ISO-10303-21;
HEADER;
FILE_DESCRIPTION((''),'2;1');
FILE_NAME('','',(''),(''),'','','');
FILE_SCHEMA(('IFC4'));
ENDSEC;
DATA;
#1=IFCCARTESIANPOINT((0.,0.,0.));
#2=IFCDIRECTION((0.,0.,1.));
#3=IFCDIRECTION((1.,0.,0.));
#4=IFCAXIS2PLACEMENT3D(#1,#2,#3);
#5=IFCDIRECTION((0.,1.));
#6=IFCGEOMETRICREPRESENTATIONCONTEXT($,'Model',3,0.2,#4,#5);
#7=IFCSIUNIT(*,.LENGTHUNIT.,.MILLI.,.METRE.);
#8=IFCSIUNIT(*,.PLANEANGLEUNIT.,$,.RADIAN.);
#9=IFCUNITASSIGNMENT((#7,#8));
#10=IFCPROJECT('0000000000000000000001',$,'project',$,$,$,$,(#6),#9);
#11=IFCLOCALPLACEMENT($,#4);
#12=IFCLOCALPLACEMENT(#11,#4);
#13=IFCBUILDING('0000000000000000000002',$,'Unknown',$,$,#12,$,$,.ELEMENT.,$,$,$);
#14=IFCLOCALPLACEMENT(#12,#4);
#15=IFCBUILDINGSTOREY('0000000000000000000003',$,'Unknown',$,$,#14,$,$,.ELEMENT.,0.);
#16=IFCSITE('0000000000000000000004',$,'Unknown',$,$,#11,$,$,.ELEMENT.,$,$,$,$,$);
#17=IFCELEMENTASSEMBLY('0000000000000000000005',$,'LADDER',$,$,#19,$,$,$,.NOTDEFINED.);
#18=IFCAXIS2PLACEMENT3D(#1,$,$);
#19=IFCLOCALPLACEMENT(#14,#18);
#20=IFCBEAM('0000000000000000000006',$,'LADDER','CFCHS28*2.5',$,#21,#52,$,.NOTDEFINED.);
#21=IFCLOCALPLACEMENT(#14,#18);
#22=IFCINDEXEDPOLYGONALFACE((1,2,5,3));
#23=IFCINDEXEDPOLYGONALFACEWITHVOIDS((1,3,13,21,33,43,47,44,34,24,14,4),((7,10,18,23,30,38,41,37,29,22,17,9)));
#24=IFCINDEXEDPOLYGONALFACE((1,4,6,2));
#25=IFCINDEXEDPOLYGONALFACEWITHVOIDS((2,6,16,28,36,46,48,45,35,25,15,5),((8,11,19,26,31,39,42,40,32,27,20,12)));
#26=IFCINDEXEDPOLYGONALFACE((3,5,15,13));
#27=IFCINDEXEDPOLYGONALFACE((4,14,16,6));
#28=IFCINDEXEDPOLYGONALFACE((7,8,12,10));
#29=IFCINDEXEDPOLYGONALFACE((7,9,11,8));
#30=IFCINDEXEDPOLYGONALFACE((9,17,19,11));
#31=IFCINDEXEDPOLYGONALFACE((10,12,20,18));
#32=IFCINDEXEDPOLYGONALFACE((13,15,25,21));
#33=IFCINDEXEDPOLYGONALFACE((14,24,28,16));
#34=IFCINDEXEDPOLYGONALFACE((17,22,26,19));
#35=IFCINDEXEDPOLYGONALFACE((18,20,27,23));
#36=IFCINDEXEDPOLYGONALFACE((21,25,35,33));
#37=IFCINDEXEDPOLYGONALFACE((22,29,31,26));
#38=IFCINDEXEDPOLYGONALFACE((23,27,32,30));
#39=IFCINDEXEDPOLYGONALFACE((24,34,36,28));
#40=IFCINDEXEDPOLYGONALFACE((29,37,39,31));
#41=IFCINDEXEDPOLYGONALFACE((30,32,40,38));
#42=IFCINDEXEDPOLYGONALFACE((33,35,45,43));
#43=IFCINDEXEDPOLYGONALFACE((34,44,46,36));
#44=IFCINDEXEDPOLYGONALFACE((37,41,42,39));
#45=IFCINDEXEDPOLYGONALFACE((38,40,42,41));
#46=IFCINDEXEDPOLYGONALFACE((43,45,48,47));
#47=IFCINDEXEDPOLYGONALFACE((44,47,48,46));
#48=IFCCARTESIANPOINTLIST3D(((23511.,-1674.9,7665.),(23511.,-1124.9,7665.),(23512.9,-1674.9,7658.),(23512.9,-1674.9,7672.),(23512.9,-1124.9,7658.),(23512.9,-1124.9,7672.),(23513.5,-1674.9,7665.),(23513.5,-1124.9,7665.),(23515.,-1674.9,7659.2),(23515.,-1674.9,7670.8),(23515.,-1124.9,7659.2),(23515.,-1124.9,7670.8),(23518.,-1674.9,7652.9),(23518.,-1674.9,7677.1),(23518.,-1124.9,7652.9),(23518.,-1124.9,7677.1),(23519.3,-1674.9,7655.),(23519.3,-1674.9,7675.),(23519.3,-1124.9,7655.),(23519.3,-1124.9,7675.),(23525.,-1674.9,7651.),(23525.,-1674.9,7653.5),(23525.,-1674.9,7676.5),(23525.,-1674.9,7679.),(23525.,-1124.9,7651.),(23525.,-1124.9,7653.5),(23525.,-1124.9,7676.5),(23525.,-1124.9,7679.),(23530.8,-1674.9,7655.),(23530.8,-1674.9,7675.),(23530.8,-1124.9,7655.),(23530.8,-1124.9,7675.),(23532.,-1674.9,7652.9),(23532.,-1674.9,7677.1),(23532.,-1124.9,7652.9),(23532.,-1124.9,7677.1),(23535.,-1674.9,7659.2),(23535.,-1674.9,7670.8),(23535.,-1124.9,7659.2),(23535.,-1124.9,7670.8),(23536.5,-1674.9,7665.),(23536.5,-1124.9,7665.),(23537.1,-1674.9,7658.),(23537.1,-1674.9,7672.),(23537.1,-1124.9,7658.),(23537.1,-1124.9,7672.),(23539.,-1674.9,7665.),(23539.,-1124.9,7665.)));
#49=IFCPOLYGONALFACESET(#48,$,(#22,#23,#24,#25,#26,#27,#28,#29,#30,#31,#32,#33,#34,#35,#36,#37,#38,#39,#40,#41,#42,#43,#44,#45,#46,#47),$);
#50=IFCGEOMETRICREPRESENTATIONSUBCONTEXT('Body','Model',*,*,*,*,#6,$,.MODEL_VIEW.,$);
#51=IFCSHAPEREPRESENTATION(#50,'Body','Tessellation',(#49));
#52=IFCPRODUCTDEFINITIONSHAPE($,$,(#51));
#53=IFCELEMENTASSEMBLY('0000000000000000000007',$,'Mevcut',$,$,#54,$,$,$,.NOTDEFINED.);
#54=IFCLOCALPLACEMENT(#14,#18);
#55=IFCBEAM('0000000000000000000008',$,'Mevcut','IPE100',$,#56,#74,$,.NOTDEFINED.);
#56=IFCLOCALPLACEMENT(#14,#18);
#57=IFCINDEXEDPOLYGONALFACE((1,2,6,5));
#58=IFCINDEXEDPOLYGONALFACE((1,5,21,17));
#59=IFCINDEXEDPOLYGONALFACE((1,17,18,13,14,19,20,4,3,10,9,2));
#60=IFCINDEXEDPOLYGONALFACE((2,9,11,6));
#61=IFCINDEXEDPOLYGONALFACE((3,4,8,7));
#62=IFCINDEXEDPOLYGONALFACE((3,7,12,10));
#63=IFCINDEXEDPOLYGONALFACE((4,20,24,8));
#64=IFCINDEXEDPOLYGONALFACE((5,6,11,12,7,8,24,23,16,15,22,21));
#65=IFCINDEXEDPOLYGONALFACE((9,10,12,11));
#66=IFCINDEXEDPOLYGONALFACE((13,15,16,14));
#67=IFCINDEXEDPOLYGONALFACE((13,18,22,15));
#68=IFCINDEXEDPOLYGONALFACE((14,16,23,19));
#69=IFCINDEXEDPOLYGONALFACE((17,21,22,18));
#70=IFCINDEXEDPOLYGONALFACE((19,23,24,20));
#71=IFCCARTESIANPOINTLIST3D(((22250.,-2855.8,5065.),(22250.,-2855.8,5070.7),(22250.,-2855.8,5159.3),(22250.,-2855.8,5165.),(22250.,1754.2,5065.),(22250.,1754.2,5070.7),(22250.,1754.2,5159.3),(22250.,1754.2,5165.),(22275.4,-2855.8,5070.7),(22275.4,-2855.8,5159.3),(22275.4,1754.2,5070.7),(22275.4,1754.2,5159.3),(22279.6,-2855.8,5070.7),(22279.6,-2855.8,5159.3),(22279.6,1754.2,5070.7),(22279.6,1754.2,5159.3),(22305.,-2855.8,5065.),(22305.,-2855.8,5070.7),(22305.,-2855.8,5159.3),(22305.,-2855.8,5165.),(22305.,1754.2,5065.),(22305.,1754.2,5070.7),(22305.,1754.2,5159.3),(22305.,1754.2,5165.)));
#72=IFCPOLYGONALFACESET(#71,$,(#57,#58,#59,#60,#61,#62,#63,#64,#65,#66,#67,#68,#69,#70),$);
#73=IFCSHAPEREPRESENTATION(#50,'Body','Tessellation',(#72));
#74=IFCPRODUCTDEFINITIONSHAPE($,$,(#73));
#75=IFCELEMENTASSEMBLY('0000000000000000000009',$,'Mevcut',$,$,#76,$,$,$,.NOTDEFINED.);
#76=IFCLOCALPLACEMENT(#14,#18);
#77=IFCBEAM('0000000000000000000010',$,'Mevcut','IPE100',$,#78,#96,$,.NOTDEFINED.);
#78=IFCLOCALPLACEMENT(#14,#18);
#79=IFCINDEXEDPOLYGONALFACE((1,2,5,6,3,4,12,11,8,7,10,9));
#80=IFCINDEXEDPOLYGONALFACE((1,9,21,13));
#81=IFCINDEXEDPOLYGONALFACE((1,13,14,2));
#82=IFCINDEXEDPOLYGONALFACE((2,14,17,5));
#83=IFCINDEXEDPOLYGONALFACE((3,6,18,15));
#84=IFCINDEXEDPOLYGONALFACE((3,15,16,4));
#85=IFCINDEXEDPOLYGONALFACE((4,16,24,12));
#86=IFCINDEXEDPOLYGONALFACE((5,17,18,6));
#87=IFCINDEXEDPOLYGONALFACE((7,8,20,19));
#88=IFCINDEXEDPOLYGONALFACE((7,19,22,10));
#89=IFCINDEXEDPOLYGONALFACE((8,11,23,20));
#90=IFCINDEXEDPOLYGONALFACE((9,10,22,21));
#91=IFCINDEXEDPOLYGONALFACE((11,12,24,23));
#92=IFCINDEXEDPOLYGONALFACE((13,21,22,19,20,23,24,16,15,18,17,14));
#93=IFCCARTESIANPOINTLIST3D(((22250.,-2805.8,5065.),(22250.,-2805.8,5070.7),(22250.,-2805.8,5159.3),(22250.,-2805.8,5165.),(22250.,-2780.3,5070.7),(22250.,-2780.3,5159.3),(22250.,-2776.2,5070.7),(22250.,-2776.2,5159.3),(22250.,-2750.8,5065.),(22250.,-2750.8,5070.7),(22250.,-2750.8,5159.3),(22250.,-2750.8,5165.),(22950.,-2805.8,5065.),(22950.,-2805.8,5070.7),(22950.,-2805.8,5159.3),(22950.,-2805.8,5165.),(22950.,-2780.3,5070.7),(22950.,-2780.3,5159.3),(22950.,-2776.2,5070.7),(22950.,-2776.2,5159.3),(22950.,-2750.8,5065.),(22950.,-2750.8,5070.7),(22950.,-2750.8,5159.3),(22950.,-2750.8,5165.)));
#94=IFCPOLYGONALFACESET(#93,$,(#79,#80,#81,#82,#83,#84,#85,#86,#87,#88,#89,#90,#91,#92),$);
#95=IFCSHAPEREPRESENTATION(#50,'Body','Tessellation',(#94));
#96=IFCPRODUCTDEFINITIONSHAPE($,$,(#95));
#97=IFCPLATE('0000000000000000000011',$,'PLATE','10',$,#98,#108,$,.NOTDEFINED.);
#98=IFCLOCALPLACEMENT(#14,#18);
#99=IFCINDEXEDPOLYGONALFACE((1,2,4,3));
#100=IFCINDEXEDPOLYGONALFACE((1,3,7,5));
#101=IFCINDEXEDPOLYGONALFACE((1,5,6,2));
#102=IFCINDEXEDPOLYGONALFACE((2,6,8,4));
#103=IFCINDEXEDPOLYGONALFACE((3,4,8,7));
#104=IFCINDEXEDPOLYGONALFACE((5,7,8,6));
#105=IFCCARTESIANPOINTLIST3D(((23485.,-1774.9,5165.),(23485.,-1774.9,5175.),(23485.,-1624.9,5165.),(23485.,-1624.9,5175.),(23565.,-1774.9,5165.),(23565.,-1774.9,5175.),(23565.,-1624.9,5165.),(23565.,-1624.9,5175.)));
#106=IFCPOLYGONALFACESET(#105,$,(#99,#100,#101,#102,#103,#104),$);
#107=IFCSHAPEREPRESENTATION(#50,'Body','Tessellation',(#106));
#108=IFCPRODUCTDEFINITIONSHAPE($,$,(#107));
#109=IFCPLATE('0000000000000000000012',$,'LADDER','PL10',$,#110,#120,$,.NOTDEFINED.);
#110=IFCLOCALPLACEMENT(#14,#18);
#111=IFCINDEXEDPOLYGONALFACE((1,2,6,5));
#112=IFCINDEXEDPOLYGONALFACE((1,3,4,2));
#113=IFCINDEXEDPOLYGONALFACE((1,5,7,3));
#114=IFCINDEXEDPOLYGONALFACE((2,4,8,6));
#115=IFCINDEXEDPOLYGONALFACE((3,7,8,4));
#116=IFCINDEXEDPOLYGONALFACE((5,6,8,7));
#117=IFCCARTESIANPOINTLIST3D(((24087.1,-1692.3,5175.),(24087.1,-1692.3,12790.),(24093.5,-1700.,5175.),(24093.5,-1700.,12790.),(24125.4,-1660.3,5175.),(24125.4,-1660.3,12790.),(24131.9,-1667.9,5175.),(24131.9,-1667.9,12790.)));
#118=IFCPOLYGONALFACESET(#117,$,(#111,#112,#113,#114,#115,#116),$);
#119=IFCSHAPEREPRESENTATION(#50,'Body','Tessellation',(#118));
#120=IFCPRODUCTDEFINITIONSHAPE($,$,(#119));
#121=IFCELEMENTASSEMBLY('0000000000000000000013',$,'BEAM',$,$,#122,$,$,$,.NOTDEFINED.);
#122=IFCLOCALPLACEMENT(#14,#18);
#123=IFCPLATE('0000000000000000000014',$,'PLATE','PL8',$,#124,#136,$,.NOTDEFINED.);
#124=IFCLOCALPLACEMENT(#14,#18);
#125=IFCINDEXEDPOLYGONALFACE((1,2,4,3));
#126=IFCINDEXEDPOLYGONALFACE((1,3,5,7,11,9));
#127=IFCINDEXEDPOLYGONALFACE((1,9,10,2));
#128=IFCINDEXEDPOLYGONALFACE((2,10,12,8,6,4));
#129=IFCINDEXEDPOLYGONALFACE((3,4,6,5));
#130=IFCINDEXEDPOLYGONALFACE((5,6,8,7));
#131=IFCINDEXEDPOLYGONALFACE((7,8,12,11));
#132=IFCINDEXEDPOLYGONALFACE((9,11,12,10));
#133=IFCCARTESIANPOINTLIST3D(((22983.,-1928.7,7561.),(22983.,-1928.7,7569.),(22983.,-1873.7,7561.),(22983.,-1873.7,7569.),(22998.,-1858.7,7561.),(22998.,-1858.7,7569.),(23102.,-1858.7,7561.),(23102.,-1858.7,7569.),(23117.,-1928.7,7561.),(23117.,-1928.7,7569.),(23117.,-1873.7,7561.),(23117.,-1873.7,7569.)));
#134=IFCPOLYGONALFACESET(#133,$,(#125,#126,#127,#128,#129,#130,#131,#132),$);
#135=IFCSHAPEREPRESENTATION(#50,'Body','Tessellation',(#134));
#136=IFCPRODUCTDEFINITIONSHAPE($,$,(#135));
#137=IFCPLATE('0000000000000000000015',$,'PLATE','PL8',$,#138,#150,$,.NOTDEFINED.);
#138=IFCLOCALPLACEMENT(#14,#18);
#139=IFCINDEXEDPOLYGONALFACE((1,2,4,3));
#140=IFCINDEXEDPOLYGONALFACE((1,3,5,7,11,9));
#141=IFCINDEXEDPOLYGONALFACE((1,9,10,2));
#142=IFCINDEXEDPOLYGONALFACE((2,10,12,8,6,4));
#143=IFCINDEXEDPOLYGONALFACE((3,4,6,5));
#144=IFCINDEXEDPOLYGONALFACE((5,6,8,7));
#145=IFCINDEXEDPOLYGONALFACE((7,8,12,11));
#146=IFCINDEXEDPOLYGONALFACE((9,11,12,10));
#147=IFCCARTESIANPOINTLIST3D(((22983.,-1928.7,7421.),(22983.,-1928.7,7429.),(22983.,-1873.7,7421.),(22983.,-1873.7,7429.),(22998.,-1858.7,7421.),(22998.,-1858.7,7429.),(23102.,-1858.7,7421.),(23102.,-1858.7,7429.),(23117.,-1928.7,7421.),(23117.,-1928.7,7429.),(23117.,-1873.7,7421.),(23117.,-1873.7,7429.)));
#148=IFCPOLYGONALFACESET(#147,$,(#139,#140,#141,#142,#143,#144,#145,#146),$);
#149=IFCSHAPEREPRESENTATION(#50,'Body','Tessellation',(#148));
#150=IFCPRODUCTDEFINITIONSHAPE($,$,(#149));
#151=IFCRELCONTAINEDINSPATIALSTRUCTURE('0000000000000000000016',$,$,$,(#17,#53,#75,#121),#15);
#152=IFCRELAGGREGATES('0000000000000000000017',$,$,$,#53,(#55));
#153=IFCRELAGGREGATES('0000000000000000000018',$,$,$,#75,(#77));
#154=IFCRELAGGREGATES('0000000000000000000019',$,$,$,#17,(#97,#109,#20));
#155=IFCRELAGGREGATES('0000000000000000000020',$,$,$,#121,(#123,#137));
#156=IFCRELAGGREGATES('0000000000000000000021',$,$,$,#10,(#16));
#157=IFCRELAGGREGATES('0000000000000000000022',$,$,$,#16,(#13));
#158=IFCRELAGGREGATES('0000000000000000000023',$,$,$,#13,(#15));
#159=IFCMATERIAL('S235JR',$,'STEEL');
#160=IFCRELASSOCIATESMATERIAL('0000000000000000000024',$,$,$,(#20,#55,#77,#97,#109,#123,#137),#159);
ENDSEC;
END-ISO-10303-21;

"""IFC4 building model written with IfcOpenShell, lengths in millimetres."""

from ifc_helpers import new_model, si_unit, direction, frame, origin_with_axes, place, context, subcontext, project, spatial, line, indexed_curve, outline, extrude, material, element, aggregate, save


model = new_model("IFC4")

# Units and contexts
model_context = context("Model", 3, precision=0.2, world=origin_with_axes(), true_north=direction((0.0, 1.0)))
body_context = subcontext(model_context, "Body", "Model", "MODEL_VIEW")
ifc_project = project(units=[si_unit("LENGTHUNIT", "METRE", prefix="MILLI"), si_unit("PLANEANGLEUNIT", "RADIAN")], contexts=[model_context])

# Site, building, storey
site_placement = place(None, origin_with_axes())
site = spatial("IfcSite", under=ifc_project, at=site_placement, Name="Unknown", CompositionType="ELEMENT")
building_placement = place(site_placement, origin_with_axes())
building = spatial("IfcBuilding", under=site, at=building_placement, Name="Unknown", CompositionType="ELEMENT")
storey_placement = place(building_placement, origin_with_axes())
storey = spatial("IfcBuildingStorey", under=building, at=storey_placement, Name="Unknown", CompositionType="ELEMENT", Elevation=0.0)

# Element assembly, beam
assembly_1_placement = place(storey_placement, frame((23525.0, -1699.9, 5175.0), z_axis=(0.0, 1.0, 0.0), x_axis=(0.0, 0.0, 1.0)))
assembly_1 = element("IfcElementAssembly", 1, at=assembly_1_placement, inside=storey, Name="LADDER", PredefinedType="NOTDEFINED")
ifc_material_1 = material(Name="S235JR", Category="STEEL")
beam_1_placement = place(assembly_1_placement, frame((2490.0, 0.0, 25.0), z_axis=(0.0, -1.0, 0.0), x_axis=(0.0, 0.0, 1.0)))
beam_1 = element("IfcBeam", 2, at=beam_1_placement, material=ifc_material_1, Name="LADDER", Description="CFCHS28*2.5", PredefinedType="NOTDEFINED", context=body_context, shape_type="SolidModel", body=[
    extrude(outline(indexed_curve([(14.0, 0.0), (12.1, 7.0), (7.0, 12.1), (0.0, 14.0), (-7.0, 12.1), (-12.1, 7.0), (-14.0, 0.0), (-12.1, -7.0), (-7.0, -12.1), (0.0, -14.0), (7.0, -12.1), (12.1, -7.0)], segments=[line(1, 2, 3, 4, 5, 6, 7, 8, 9, 10, 11, 12, 1)]), holes=[indexed_curve([(11.5, 0.0), (10.0, -5.8), (5.8, -10.0), (0.0, -11.5), (-5.8, -10.0), (-10.0, -5.8), (-11.5, 0.0), (-10.0, 5.8), (-5.8, 10.0), (0.0, 11.5), (5.8, 10.0), (10.0, 5.8)], segments=[line(1, 2, 3, 4, 5, 6, 7, 8, 9, 10, 11, 12, 1)])]), frame((0.0, 0.0, 0.0), z_axis=(-1.0, 0.0, 0.0), x_axis=(0.0, 0.0, 1.0)), (0.0, 0.0, -1.0), 550.0),
])

# Element assemblies, beams
assembly_2_placement = place(storey_placement, frame((22277.5, -2855.8, 5115.0), z_axis=(1.0, 0.0, 0.0), x_axis=(0.0, 1.0, 0.0)))
assembly_2 = element("IfcElementAssembly", 3, at=assembly_2_placement, inside=storey, Name="Mevcut", PredefinedType="NOTDEFINED")
beam_2_placement = place(assembly_2_placement, origin_with_axes())
beam_2 = element("IfcBeam", 4, at=beam_2_placement, material=ifc_material_1, Name="Mevcut", Description="IPE100", PredefinedType="NOTDEFINED", context=body_context, shape_type="SolidModel", body=[
    extrude(outline(indexed_curve([(-27.5, -50.0), (27.5, -50.0), (27.5, -44.3), (2.0, -44.3), (2.0, 44.3), (27.5, 44.3), (27.5, 50.0), (-27.5, 50.0), (-27.5, 44.3), (-2.0, 44.3), (-2.0, -44.3), (-27.5, -44.3)], segments=[line(1, 2, 3, 4, 5, 6, 7, 8, 9, 10, 11, 12, 1)])), frame((0.0, 0.0, 0.0), z_axis=(-1.0, 0.0, 0.0), x_axis=(0.0, 0.0, 1.0)), (0.0, 0.0, -1.0), 4610.0),
])
aggregate(assembly_2, [beam_2])
assembly_3_placement = place(storey_placement, frame((22950.0, -2778.3, 5115.0), z_axis=(0.0, -1.0, 0.0), x_axis=(-1.0, 0.0, 0.0)))
assembly_3 = element("IfcElementAssembly", 5, at=assembly_3_placement, inside=storey, Name="Mevcut", PredefinedType="NOTDEFINED")
beam_3_placement = place(assembly_3_placement, origin_with_axes())
beam_3 = element("IfcBeam", 6, at=beam_3_placement, material=ifc_material_1, Name="Mevcut", Description="IPE100", PredefinedType="NOTDEFINED", context=body_context, shape_type="SolidModel", body=[
    extrude(outline(indexed_curve([(-27.5, -50.0), (27.5, -50.0), (27.5, -44.3), (2.0, -44.3), (2.0, 44.3), (27.5, 44.3), (27.5, 50.0), (-27.5, 50.0), (-27.5, 44.3), (-2.0, 44.3), (-2.0, -44.3), (-27.5, -44.3)], segments=[line(1, 2, 3, 4, 5, 6, 7, 8, 9, 10, 11, 12, 1)])), frame((0.0, 0.0, 0.0), z_axis=(-1.0, 0.0, 0.0), x_axis=(0.0, 0.0, 1.0)), (0.0, 0.0, -1.0), 700.0),
])
aggregate(assembly_3, [beam_3])

# Plates
plate_1_placement = place(assembly_1_placement, frame((-5.0, -40.0, 75.0), z_axis=(-1.0, 0.0, 0.0), x_axis=(0.0, 1.0, 0.0)))
plate_1 = element("IfcPlate", 7, at=plate_1_placement, material=ifc_material_1, Name="PLATE", Description="10", PredefinedType="NOTDEFINED", context=body_context, shape_type="SolidModel", body=[
    extrude(outline(indexed_curve([(0.0, 0.0), (80.0, 0.0), (80.0, 150.0), (0.0, 150.0)], segments=[line(1, 2, 3, 4, 1)])), frame((0.0, 0.0, 5.0), z_axis=(0.0, 0.0, 1.0), x_axis=(1.0, 0.0, 0.0)), (0.0, 0.0, -1.0), 10.0),
])
plate_2_placement = place(assembly_1_placement, frame((0.0, 603.6, 35.8), z_axis=(0.0, -0.641441, 0.767172), x_axis=(0.0, -0.767172, -0.641441)))
plate_2 = element("IfcPlate", 8, at=plate_2_placement, material=ifc_material_1, Name="LADDER", Description="PL10", PredefinedType="NOTDEFINED", context=body_context, shape_type="SolidModel", body=[
    extrude(outline(indexed_curve([(0.0, 0.0), (50.0, 0.0), (50.0, 7615.0), (0.0, 7615.0)], segments=[line(1, 2, 3, 4, 1)])), frame((0.0, 0.0, 5.0), z_axis=(0.0, 0.0, 1.0), x_axis=(1.0, 0.0, 0.0)), (0.0, 0.0, -1.0), 10.0),
])
aggregate(assembly_1, [plate_1, plate_2, beam_1])

# Element assembly, plates
assembly_4_placement = place(storey_placement, frame((23050.0, -1854.9, 11625.0), z_axis=(0.0, -1.0, 0.0), x_axis=(0.0, 0.0, -1.0)))
assembly_4 = element("IfcElementAssembly", 9, at=assembly_4_placement, inside=storey, Name="BEAM", PredefinedType="NOTDEFINED")
plate_3_placement = place(assembly_4_placement, frame((4060.0, -67.0, 3.8), z_axis=(-1.0, 0.0, 0.0), x_axis=(0.0, 0.0, 1.0)))
plate_3 = element("IfcPlate", 10, at=plate_3_placement, material=ifc_material_1, Name="PLATE", Description="PL8", PredefinedType="NOTDEFINED", context=body_context, shape_type="SolidModel", body=[
    extrude(outline(indexed_curve([(0.0, 15.0), (15.0, 0.0), (70.0, 0.0), (70.0, 134.0), (15.0, 134.0), (0.0, 119.0)], segments=[line(1, 2, 3, 4, 5, 6, 1)])), frame((0.0, 0.0, 4.0), z_axis=(0.0, 0.0, 1.0), x_axis=(1.0, 0.0, 0.0)), (0.0, 0.0, -1.0), 8.0),
])
plate_4_placement = place(assembly_4_placement, frame((4200.0, -67.0, 3.8), z_axis=(-1.0, 0.0, 0.0), x_axis=(0.0, 0.0, 1.0)))
plate_4 = element("IfcPlate", 11, at=plate_4_placement, material=ifc_material_1, Name="PLATE", Description="PL8", PredefinedType="NOTDEFINED", context=body_context, shape_type="SolidModel", body=[
    extrude(outline(indexed_curve([(0.0, 15.0), (15.0, 0.0), (70.0, 0.0), (70.0, 134.0), (15.0, 134.0), (0.0, 119.0)], segments=[line(1, 2, 3, 4, 5, 6, 1)])), frame((0.0, 0.0, 4.0), z_axis=(0.0, 0.0, 1.0), x_axis=(1.0, 0.0, 0.0)), (0.0, 0.0, -1.0), 8.0),
])
aggregate(assembly_4, [plate_3, plate_4])

save(model, "model.ifc")
